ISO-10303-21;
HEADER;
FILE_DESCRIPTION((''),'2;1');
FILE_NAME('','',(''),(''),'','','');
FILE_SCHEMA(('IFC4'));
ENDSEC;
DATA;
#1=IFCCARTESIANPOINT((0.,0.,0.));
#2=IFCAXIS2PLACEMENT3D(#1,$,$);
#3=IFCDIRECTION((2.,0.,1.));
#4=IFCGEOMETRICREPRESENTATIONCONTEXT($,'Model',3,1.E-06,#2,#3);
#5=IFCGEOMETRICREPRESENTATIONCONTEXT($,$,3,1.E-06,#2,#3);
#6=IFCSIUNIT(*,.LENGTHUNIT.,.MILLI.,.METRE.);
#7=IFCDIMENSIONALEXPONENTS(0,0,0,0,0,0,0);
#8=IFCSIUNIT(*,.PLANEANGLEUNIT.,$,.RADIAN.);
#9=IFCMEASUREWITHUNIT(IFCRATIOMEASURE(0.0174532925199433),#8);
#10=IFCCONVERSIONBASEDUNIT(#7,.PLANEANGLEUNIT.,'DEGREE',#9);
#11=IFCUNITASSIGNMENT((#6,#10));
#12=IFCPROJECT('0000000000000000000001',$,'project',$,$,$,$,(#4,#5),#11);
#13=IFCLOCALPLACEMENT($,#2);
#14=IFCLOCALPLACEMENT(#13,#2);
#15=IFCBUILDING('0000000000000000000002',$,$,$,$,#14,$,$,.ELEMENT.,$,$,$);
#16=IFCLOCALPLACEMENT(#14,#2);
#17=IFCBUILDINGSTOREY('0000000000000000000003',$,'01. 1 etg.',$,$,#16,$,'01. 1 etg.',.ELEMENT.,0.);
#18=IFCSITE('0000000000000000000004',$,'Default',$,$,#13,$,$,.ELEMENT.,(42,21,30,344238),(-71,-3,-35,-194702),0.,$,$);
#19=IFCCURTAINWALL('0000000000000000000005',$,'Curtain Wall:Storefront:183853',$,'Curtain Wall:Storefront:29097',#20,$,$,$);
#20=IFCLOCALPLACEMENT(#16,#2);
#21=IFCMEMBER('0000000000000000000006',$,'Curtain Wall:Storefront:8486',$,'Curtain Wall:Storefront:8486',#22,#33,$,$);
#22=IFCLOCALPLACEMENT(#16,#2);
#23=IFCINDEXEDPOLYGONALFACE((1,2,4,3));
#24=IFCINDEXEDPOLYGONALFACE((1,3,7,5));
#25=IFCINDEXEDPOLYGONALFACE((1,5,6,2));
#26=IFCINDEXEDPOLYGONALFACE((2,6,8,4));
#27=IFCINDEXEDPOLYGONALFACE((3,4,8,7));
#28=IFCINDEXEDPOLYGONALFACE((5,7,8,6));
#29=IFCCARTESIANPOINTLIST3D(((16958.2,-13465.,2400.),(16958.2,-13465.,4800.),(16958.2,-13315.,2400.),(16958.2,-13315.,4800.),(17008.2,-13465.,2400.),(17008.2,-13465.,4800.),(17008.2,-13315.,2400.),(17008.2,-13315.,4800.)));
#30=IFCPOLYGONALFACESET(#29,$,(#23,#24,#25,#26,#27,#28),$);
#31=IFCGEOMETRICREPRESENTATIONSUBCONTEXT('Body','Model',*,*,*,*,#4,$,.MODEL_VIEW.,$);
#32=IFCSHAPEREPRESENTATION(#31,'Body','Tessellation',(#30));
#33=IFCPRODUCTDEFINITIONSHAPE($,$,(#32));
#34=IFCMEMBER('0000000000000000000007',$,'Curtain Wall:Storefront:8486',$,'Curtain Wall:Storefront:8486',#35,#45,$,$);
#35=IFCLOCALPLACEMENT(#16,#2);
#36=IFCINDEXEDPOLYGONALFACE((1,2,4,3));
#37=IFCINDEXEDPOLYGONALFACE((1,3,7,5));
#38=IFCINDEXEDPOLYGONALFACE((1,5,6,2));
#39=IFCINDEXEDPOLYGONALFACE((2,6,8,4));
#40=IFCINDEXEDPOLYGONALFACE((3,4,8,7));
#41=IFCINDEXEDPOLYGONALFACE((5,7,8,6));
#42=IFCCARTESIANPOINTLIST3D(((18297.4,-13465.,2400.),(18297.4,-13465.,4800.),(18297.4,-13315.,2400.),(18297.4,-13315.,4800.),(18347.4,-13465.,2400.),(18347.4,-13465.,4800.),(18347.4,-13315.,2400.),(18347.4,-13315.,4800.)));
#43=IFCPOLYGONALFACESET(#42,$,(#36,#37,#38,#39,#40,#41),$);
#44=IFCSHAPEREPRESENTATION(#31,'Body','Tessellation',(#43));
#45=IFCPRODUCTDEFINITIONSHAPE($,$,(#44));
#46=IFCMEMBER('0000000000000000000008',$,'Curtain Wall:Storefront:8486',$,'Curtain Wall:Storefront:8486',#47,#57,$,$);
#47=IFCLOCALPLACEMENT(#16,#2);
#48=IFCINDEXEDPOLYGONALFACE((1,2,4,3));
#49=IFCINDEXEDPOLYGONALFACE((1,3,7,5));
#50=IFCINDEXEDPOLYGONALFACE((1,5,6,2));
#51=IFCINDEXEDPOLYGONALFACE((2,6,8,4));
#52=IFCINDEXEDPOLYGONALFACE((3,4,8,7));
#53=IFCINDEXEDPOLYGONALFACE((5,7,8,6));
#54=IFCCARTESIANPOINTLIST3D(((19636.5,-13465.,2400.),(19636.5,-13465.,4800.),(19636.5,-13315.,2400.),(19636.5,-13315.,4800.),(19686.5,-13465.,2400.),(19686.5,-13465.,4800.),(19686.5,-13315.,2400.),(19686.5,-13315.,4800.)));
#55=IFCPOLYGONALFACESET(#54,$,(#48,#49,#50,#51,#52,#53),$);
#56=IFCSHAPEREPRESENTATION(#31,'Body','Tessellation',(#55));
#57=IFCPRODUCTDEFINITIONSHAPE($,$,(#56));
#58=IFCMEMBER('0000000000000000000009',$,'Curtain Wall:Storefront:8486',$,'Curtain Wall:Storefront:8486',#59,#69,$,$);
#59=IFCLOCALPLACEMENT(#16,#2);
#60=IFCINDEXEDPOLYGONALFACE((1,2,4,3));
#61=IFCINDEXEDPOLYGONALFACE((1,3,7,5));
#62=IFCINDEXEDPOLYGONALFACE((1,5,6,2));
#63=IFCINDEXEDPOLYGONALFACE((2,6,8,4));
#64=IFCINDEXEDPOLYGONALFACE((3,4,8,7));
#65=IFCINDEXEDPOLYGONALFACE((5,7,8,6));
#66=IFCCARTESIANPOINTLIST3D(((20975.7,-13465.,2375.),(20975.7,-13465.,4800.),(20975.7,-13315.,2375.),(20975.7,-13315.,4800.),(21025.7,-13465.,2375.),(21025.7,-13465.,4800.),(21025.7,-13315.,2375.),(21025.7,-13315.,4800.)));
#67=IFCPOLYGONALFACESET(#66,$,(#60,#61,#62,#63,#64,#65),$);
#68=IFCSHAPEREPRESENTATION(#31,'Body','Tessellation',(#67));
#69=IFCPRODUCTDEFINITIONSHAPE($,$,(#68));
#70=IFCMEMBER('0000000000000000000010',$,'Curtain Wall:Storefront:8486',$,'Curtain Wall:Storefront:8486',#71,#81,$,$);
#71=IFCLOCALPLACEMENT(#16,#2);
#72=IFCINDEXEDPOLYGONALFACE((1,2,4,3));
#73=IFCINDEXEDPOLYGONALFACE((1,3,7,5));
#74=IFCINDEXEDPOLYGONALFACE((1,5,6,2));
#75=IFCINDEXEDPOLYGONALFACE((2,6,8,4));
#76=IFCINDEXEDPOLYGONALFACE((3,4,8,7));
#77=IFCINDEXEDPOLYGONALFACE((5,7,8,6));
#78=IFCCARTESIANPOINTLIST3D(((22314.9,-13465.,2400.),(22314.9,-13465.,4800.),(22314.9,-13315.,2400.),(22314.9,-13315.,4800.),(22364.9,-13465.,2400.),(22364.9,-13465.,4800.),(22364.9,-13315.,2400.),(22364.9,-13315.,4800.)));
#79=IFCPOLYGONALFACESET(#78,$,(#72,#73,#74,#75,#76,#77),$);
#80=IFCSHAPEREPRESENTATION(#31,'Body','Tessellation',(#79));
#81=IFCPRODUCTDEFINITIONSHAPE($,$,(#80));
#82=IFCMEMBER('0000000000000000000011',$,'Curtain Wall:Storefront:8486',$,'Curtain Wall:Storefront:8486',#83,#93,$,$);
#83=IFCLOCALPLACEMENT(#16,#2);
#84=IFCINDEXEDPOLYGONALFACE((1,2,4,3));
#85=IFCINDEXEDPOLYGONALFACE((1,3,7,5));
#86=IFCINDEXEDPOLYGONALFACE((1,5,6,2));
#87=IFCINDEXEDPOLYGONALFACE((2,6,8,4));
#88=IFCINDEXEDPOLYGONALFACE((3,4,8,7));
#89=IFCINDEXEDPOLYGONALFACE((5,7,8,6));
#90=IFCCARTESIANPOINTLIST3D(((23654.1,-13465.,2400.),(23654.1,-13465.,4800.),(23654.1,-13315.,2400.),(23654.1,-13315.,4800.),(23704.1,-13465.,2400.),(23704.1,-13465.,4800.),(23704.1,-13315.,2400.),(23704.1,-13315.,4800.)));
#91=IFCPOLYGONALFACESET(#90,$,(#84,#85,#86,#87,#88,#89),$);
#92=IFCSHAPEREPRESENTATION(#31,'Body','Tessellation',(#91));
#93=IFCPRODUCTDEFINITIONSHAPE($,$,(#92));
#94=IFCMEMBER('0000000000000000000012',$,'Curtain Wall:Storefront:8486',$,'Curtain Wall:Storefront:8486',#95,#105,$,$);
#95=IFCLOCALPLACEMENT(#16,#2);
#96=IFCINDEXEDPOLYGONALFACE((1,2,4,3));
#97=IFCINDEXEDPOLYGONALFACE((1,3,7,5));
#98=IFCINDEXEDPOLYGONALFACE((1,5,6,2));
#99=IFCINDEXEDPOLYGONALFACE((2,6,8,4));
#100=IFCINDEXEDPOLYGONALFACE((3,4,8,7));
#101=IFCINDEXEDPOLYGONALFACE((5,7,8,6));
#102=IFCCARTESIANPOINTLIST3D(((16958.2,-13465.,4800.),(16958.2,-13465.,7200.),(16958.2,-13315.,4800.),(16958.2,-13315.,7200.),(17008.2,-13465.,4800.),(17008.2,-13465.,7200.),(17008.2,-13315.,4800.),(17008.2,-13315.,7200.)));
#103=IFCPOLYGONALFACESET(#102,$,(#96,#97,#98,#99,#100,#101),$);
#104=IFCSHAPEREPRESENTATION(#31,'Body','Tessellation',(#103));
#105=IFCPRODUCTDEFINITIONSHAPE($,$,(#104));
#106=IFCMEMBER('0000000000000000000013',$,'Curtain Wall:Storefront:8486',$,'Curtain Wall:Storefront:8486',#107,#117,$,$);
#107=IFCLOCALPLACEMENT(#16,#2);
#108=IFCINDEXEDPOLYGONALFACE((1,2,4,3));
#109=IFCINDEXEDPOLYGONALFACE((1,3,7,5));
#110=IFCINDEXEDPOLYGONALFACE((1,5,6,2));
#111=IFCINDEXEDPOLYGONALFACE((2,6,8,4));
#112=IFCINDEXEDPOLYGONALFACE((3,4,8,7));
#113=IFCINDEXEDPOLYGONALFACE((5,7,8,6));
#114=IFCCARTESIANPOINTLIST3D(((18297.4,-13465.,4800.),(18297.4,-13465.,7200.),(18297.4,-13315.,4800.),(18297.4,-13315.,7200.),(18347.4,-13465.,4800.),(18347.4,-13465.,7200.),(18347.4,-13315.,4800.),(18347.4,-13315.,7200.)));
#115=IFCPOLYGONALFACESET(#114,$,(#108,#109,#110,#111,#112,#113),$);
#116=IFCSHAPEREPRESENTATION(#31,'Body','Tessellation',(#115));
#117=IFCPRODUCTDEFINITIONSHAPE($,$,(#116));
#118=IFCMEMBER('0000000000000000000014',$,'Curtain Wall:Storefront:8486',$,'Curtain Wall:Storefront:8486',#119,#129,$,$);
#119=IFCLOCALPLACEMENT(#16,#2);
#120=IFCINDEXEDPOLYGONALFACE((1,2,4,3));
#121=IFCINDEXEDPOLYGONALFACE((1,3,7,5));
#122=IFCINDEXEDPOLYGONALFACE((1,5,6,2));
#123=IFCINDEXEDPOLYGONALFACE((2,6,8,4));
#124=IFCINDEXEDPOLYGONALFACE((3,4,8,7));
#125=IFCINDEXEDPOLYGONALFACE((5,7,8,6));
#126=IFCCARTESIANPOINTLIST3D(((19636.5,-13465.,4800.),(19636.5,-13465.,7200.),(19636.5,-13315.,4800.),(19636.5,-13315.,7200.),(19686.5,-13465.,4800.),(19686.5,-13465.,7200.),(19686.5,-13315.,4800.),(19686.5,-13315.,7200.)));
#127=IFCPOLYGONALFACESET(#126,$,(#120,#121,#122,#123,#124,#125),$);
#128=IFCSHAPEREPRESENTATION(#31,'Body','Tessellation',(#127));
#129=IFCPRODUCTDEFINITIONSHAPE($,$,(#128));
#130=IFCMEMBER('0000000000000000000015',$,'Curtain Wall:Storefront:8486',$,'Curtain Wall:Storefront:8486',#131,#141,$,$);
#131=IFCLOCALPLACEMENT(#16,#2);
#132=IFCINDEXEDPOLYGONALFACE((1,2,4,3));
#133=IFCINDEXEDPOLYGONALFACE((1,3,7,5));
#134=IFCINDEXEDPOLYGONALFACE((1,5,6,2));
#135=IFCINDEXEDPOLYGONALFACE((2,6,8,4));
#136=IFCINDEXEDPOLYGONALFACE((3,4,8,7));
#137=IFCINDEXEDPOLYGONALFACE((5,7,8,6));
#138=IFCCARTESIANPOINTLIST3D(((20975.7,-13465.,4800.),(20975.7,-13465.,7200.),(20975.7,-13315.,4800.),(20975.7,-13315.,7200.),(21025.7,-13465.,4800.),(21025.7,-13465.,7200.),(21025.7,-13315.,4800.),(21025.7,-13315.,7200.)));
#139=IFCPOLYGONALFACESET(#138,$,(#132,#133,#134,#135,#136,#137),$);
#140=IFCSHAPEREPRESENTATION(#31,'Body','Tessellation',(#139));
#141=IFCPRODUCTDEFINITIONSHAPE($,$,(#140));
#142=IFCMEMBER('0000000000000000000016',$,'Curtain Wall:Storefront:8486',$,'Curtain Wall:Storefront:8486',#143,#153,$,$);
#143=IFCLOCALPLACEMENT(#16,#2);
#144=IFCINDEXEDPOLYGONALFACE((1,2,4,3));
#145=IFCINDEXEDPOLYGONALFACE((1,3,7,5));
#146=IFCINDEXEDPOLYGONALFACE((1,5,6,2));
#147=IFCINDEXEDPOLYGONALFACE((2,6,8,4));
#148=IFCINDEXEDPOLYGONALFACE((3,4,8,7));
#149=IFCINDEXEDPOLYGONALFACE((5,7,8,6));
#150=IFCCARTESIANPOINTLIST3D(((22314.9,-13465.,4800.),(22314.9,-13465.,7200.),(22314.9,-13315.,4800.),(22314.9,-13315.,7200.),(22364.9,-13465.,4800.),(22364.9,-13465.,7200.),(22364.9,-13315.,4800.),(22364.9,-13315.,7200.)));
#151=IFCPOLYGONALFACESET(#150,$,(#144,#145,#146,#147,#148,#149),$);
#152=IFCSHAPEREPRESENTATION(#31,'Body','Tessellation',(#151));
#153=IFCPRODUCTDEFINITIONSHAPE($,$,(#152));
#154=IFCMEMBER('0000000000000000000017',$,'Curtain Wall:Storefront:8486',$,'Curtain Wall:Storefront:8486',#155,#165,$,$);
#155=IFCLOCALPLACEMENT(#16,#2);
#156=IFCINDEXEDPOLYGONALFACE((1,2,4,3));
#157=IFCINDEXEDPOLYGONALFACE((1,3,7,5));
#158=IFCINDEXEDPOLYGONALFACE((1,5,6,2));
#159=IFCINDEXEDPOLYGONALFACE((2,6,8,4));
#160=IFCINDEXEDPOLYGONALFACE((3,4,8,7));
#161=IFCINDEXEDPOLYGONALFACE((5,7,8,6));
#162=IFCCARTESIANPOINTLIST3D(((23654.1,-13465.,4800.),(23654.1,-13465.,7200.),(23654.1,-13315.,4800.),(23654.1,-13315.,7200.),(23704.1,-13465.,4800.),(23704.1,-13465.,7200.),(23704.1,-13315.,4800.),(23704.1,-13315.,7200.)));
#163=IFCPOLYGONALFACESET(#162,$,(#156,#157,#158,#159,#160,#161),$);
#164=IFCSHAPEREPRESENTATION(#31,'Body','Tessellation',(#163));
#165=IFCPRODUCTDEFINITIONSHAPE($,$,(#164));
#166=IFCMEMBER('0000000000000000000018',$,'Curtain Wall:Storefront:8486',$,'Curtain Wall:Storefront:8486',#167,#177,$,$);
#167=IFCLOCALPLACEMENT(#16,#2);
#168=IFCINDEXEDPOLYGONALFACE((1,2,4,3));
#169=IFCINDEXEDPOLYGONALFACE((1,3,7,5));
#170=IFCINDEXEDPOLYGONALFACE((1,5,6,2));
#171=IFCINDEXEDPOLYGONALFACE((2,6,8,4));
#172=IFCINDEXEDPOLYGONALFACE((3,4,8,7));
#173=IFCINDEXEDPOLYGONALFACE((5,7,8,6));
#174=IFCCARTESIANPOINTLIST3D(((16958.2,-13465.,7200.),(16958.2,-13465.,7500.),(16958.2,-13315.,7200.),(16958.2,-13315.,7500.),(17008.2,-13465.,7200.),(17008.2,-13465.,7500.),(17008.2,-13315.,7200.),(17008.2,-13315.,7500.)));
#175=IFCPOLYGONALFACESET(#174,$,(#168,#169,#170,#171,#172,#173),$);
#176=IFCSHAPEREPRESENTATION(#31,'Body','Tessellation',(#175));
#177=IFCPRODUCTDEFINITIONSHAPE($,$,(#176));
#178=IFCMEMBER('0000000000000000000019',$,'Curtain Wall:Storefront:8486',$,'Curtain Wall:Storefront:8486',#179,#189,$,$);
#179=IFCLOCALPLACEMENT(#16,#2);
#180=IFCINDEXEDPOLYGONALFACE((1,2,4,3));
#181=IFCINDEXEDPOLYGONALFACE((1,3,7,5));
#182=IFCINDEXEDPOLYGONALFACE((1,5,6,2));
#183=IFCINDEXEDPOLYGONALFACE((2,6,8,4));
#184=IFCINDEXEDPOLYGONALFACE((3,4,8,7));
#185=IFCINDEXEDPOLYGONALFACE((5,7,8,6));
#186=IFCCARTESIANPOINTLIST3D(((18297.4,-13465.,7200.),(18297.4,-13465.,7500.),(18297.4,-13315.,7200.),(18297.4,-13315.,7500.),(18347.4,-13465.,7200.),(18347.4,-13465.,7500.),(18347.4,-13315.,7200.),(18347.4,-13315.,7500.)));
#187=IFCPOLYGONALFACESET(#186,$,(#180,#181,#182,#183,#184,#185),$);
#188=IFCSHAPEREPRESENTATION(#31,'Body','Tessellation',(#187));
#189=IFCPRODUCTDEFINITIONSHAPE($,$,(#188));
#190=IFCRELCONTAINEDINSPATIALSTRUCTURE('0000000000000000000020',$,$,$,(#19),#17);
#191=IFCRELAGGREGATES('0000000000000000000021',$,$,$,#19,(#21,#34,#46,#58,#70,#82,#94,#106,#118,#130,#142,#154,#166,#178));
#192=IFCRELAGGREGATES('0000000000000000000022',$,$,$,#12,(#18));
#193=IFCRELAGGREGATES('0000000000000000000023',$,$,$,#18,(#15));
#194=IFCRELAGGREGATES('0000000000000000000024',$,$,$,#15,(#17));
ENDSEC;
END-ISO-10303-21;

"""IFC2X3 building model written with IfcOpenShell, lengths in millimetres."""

from ifc_helpers import new_model, entity, si_unit, converted_unit, direction, frame, frame_2d, origin, place, context, subcontext, project, spatial, rectangle, extrude, element, aggregate, save


model = new_model("IFC2X3")

# Units and contexts
model_context = context("Model", 3, precision=1e-06, world=origin(), true_north=direction((2.0, 0.0, 1.0)))
context_of_model = context(None, 3, precision=1e-06, world=origin(), true_north=direction((2.0, 0.0, 1.0)))
body_context = subcontext(model_context, "Body", "Model", "MODEL_VIEW")
ifc_project = project(units=[si_unit("LENGTHUNIT", "METRE", prefix="MILLI"), converted_unit("PLANEANGLEUNIT", "DEGREE", entity("IfcRatioMeasure", 0.0174532925199433), si_unit("PLANEANGLEUNIT", "RADIAN"), dimensions=[0, 0, 0, 0, 0, 0, 0])], contexts=[model_context, context_of_model])

# Site, building, storey
site_placement = place(None, origin())
site = spatial("IfcSite", under=ifc_project, at=site_placement, Name="Default", CompositionType="ELEMENT", RefLatitude=(42, 21, 30, 344238), RefLongitude=(-71, -3, -35, -194702), RefElevation=0.0)
building_placement = place(site_placement, origin())
building = spatial("IfcBuilding", under=site, at=building_placement, CompositionType="ELEMENT")
storey_placement = place(building_placement, origin())
storey = spatial("IfcBuildingStorey", under=building, at=storey_placement, Name="01. 1 etg.", LongName="01. 1 etg.", CompositionType="ELEMENT", Elevation=0.0)

# Curtain wall, members
curtain_wall_placement = place(storey_placement, origin())
curtain_wall = element("IfcCurtainWall", 1, at=curtain_wall_placement, inside=storey, Name="Curtain Wall:Storefront:183853", ObjectType="Curtain Wall:Storefront:29097")
member_1_placement = place(storey_placement, origin())
member_1 = element("IfcMember", 2, at=member_1_placement, Name="Curtain Wall:Storefront:8486", ObjectType="Curtain Wall:Storefront:8486", context=body_context, shape_type="SweptSolid", body=[
    extrude(rectangle(XDim=150.0, YDim=50.0, at=frame_2d((0.0, 0.0), x_axis=(1.0, 0.0))), frame((16983.2, -13390.0, 2400.0), z_axis=(0.0, 0.0, 1.0), x_axis=(0.0, 1.0, 0.0)), (0.0, 0.0, 1.0), 2400.0),
])
member_2_placement = place(storey_placement, origin())
member_2 = element("IfcMember", 3, at=member_2_placement, Name="Curtain Wall:Storefront:8486", ObjectType="Curtain Wall:Storefront:8486", context=body_context, shape_type="SweptSolid", body=[
    extrude(rectangle(XDim=150.0, YDim=50.0, at=frame_2d((0.0, 0.0), x_axis=(1.0, 0.0))), frame((18322.4, -13390.0, 2400.0), z_axis=(0.0, 0.0, 1.0), x_axis=(0.0, 1.0, 0.0)), (0.0, 0.0, 1.0), 2400.0),
])
member_3_placement = place(storey_placement, origin())
member_3 = element("IfcMember", 4, at=member_3_placement, Name="Curtain Wall:Storefront:8486", ObjectType="Curtain Wall:Storefront:8486", context=body_context, shape_type="SweptSolid", body=[
    extrude(rectangle(XDim=150.0, YDim=50.0, at=frame_2d((0.0, 0.0), x_axis=(1.0, 0.0))), frame((19661.5, -13390.0, 2400.0), z_axis=(0.0, 0.0, 1.0), x_axis=(0.0, 1.0, 0.0)), (0.0, 0.0, 1.0), 2400.0),
])
member_4_placement = place(storey_placement, origin())
member_4 = element("IfcMember", 5, at=member_4_placement, Name="Curtain Wall:Storefront:8486", ObjectType="Curtain Wall:Storefront:8486", context=body_context, shape_type="SweptSolid", body=[
    extrude(rectangle(XDim=150.0, YDim=50.0, at=frame_2d((0.0, 0.0), x_axis=(1.0, 0.0))), frame((21000.7, -13390.0, 2375.0), z_axis=(0.0, 0.0, 1.0), x_axis=(0.0, 1.0, 0.0)), (0.0, 0.0, 1.0), 2425.0),
])
member_5_placement = place(storey_placement, origin())
member_5 = element("IfcMember", 6, at=member_5_placement, Name="Curtain Wall:Storefront:8486", ObjectType="Curtain Wall:Storefront:8486", context=body_context, shape_type="SweptSolid", body=[
    extrude(rectangle(XDim=150.0, YDim=50.0, at=frame_2d((0.0, 0.0), x_axis=(1.0, 0.0))), frame((22339.9, -13390.0, 2400.0), z_axis=(0.0, 0.0, 1.0), x_axis=(0.0, 1.0, 0.0)), (0.0, 0.0, 1.0), 2400.0),
])
member_6_placement = place(storey_placement, origin())
member_6 = element("IfcMember", 7, at=member_6_placement, Name="Curtain Wall:Storefront:8486", ObjectType="Curtain Wall:Storefront:8486", context=body_context, shape_type="SweptSolid", body=[
    extrude(rectangle(XDim=150.0, YDim=50.0, at=frame_2d((0.0, 0.0), x_axis=(1.0, 0.0))), frame((23679.1, -13390.0, 2400.0), z_axis=(0.0, 0.0, 1.0), x_axis=(0.0, 1.0, 0.0)), (0.0, 0.0, 1.0), 2400.0),
])
member_7_placement = place(storey_placement, origin())
member_7 = element("IfcMember", 8, at=member_7_placement, Name="Curtain Wall:Storefront:8486", ObjectType="Curtain Wall:Storefront:8486", context=body_context, shape_type="SweptSolid", body=[
    extrude(rectangle(XDim=150.0, YDim=50.0, at=frame_2d((0.0, 0.0), x_axis=(1.0, 0.0))), frame((16983.2, -13390.0, 4800.0), z_axis=(0.0, 0.0, 1.0), x_axis=(0.0, 1.0, 0.0)), (0.0, 0.0, 1.0), 2400.0),
])
member_8_placement = place(storey_placement, origin())
member_8 = element("IfcMember", 9, at=member_8_placement, Name="Curtain Wall:Storefront:8486", ObjectType="Curtain Wall:Storefront:8486", context=body_context, shape_type="SweptSolid", body=[
    extrude(rectangle(XDim=150.0, YDim=50.0, at=frame_2d((0.0, 0.0), x_axis=(1.0, 0.0))), frame((18322.4, -13390.0, 4800.0), z_axis=(0.0, 0.0, 1.0), x_axis=(0.0, 1.0, 0.0)), (0.0, 0.0, 1.0), 2400.0),
])
member_9_placement = place(storey_placement, origin())
member_9 = element("IfcMember", 10, at=member_9_placement, Name="Curtain Wall:Storefront:8486", ObjectType="Curtain Wall:Storefront:8486", context=body_context, shape_type="SweptSolid", body=[
    extrude(rectangle(XDim=150.0, YDim=50.0, at=frame_2d((0.0, 0.0), x_axis=(1.0, 0.0))), frame((19661.5, -13390.0, 4800.0), z_axis=(0.0, 0.0, 1.0), x_axis=(0.0, 1.0, 0.0)), (0.0, 0.0, 1.0), 2400.0),
])
member_10_placement = place(storey_placement, origin())
member_10 = element("IfcMember", 11, at=member_10_placement, Name="Curtain Wall:Storefront:8486", ObjectType="Curtain Wall:Storefront:8486", context=body_context, shape_type="SweptSolid", body=[
    extrude(rectangle(XDim=150.0, YDim=50.0, at=frame_2d((0.0, 0.0), x_axis=(1.0, 0.0))), frame((21000.7, -13390.0, 4800.0), z_axis=(0.0, 0.0, 1.0), x_axis=(0.0, 1.0, 0.0)), (0.0, 0.0, 1.0), 2400.0),
])
member_11_placement = place(storey_placement, origin())
member_11 = element("IfcMember", 12, at=member_11_placement, Name="Curtain Wall:Storefront:8486", ObjectType="Curtain Wall:Storefront:8486", context=body_context, shape_type="SweptSolid", body=[
    extrude(rectangle(XDim=150.0, YDim=50.0, at=frame_2d((0.0, 0.0), x_axis=(1.0, 0.0))), frame((22339.9, -13390.0, 4800.0), z_axis=(0.0, 0.0, 1.0), x_axis=(0.0, 1.0, 0.0)), (0.0, 0.0, 1.0), 2400.0),
])
member_12_placement = place(storey_placement, origin())
member_12 = element("IfcMember", 13, at=member_12_placement, Name="Curtain Wall:Storefront:8486", ObjectType="Curtain Wall:Storefront:8486", context=body_context, shape_type="SweptSolid", body=[
    extrude(rectangle(XDim=150.0, YDim=50.0, at=frame_2d((0.0, 0.0), x_axis=(1.0, 0.0))), frame((23679.1, -13390.0, 4800.0), z_axis=(0.0, 0.0, 1.0), x_axis=(0.0, 1.0, 0.0)), (0.0, 0.0, 1.0), 2400.0),
])
member_13_placement = place(storey_placement, origin())
member_13 = element("IfcMember", 14, at=member_13_placement, Name="Curtain Wall:Storefront:8486", ObjectType="Curtain Wall:Storefront:8486", context=body_context, shape_type="SweptSolid", body=[
    extrude(rectangle(XDim=150.0, YDim=50.0, at=frame_2d((0.0, 0.0), x_axis=(1.0, 0.0))), frame((16983.2, -13390.0, 7200.0), z_axis=(0.0, 0.0, 1.0), x_axis=(0.0, 1.0, 0.0)), (0.0, 0.0, 1.0), 300.0),
])
member_14_placement = place(storey_placement, origin())
member_14 = element("IfcMember", 15, at=member_14_placement, Name="Curtain Wall:Storefront:8486", ObjectType="Curtain Wall:Storefront:8486", context=body_context, shape_type="SweptSolid", body=[
    extrude(rectangle(XDim=150.0, YDim=50.0, at=frame_2d((0.0, 0.0), x_axis=(1.0, 0.0))), frame((18322.4, -13390.0, 7200.0), z_axis=(0.0, 0.0, 1.0), x_axis=(0.0, 1.0, 0.0)), (0.0, 0.0, 1.0), 300.0),
])
aggregate(curtain_wall, [member_1, member_2, member_3, member_4, member_5, member_6, member_7, member_8, member_9, member_10, member_11, member_12, member_13, member_14])

save(model, "model.ifc")
